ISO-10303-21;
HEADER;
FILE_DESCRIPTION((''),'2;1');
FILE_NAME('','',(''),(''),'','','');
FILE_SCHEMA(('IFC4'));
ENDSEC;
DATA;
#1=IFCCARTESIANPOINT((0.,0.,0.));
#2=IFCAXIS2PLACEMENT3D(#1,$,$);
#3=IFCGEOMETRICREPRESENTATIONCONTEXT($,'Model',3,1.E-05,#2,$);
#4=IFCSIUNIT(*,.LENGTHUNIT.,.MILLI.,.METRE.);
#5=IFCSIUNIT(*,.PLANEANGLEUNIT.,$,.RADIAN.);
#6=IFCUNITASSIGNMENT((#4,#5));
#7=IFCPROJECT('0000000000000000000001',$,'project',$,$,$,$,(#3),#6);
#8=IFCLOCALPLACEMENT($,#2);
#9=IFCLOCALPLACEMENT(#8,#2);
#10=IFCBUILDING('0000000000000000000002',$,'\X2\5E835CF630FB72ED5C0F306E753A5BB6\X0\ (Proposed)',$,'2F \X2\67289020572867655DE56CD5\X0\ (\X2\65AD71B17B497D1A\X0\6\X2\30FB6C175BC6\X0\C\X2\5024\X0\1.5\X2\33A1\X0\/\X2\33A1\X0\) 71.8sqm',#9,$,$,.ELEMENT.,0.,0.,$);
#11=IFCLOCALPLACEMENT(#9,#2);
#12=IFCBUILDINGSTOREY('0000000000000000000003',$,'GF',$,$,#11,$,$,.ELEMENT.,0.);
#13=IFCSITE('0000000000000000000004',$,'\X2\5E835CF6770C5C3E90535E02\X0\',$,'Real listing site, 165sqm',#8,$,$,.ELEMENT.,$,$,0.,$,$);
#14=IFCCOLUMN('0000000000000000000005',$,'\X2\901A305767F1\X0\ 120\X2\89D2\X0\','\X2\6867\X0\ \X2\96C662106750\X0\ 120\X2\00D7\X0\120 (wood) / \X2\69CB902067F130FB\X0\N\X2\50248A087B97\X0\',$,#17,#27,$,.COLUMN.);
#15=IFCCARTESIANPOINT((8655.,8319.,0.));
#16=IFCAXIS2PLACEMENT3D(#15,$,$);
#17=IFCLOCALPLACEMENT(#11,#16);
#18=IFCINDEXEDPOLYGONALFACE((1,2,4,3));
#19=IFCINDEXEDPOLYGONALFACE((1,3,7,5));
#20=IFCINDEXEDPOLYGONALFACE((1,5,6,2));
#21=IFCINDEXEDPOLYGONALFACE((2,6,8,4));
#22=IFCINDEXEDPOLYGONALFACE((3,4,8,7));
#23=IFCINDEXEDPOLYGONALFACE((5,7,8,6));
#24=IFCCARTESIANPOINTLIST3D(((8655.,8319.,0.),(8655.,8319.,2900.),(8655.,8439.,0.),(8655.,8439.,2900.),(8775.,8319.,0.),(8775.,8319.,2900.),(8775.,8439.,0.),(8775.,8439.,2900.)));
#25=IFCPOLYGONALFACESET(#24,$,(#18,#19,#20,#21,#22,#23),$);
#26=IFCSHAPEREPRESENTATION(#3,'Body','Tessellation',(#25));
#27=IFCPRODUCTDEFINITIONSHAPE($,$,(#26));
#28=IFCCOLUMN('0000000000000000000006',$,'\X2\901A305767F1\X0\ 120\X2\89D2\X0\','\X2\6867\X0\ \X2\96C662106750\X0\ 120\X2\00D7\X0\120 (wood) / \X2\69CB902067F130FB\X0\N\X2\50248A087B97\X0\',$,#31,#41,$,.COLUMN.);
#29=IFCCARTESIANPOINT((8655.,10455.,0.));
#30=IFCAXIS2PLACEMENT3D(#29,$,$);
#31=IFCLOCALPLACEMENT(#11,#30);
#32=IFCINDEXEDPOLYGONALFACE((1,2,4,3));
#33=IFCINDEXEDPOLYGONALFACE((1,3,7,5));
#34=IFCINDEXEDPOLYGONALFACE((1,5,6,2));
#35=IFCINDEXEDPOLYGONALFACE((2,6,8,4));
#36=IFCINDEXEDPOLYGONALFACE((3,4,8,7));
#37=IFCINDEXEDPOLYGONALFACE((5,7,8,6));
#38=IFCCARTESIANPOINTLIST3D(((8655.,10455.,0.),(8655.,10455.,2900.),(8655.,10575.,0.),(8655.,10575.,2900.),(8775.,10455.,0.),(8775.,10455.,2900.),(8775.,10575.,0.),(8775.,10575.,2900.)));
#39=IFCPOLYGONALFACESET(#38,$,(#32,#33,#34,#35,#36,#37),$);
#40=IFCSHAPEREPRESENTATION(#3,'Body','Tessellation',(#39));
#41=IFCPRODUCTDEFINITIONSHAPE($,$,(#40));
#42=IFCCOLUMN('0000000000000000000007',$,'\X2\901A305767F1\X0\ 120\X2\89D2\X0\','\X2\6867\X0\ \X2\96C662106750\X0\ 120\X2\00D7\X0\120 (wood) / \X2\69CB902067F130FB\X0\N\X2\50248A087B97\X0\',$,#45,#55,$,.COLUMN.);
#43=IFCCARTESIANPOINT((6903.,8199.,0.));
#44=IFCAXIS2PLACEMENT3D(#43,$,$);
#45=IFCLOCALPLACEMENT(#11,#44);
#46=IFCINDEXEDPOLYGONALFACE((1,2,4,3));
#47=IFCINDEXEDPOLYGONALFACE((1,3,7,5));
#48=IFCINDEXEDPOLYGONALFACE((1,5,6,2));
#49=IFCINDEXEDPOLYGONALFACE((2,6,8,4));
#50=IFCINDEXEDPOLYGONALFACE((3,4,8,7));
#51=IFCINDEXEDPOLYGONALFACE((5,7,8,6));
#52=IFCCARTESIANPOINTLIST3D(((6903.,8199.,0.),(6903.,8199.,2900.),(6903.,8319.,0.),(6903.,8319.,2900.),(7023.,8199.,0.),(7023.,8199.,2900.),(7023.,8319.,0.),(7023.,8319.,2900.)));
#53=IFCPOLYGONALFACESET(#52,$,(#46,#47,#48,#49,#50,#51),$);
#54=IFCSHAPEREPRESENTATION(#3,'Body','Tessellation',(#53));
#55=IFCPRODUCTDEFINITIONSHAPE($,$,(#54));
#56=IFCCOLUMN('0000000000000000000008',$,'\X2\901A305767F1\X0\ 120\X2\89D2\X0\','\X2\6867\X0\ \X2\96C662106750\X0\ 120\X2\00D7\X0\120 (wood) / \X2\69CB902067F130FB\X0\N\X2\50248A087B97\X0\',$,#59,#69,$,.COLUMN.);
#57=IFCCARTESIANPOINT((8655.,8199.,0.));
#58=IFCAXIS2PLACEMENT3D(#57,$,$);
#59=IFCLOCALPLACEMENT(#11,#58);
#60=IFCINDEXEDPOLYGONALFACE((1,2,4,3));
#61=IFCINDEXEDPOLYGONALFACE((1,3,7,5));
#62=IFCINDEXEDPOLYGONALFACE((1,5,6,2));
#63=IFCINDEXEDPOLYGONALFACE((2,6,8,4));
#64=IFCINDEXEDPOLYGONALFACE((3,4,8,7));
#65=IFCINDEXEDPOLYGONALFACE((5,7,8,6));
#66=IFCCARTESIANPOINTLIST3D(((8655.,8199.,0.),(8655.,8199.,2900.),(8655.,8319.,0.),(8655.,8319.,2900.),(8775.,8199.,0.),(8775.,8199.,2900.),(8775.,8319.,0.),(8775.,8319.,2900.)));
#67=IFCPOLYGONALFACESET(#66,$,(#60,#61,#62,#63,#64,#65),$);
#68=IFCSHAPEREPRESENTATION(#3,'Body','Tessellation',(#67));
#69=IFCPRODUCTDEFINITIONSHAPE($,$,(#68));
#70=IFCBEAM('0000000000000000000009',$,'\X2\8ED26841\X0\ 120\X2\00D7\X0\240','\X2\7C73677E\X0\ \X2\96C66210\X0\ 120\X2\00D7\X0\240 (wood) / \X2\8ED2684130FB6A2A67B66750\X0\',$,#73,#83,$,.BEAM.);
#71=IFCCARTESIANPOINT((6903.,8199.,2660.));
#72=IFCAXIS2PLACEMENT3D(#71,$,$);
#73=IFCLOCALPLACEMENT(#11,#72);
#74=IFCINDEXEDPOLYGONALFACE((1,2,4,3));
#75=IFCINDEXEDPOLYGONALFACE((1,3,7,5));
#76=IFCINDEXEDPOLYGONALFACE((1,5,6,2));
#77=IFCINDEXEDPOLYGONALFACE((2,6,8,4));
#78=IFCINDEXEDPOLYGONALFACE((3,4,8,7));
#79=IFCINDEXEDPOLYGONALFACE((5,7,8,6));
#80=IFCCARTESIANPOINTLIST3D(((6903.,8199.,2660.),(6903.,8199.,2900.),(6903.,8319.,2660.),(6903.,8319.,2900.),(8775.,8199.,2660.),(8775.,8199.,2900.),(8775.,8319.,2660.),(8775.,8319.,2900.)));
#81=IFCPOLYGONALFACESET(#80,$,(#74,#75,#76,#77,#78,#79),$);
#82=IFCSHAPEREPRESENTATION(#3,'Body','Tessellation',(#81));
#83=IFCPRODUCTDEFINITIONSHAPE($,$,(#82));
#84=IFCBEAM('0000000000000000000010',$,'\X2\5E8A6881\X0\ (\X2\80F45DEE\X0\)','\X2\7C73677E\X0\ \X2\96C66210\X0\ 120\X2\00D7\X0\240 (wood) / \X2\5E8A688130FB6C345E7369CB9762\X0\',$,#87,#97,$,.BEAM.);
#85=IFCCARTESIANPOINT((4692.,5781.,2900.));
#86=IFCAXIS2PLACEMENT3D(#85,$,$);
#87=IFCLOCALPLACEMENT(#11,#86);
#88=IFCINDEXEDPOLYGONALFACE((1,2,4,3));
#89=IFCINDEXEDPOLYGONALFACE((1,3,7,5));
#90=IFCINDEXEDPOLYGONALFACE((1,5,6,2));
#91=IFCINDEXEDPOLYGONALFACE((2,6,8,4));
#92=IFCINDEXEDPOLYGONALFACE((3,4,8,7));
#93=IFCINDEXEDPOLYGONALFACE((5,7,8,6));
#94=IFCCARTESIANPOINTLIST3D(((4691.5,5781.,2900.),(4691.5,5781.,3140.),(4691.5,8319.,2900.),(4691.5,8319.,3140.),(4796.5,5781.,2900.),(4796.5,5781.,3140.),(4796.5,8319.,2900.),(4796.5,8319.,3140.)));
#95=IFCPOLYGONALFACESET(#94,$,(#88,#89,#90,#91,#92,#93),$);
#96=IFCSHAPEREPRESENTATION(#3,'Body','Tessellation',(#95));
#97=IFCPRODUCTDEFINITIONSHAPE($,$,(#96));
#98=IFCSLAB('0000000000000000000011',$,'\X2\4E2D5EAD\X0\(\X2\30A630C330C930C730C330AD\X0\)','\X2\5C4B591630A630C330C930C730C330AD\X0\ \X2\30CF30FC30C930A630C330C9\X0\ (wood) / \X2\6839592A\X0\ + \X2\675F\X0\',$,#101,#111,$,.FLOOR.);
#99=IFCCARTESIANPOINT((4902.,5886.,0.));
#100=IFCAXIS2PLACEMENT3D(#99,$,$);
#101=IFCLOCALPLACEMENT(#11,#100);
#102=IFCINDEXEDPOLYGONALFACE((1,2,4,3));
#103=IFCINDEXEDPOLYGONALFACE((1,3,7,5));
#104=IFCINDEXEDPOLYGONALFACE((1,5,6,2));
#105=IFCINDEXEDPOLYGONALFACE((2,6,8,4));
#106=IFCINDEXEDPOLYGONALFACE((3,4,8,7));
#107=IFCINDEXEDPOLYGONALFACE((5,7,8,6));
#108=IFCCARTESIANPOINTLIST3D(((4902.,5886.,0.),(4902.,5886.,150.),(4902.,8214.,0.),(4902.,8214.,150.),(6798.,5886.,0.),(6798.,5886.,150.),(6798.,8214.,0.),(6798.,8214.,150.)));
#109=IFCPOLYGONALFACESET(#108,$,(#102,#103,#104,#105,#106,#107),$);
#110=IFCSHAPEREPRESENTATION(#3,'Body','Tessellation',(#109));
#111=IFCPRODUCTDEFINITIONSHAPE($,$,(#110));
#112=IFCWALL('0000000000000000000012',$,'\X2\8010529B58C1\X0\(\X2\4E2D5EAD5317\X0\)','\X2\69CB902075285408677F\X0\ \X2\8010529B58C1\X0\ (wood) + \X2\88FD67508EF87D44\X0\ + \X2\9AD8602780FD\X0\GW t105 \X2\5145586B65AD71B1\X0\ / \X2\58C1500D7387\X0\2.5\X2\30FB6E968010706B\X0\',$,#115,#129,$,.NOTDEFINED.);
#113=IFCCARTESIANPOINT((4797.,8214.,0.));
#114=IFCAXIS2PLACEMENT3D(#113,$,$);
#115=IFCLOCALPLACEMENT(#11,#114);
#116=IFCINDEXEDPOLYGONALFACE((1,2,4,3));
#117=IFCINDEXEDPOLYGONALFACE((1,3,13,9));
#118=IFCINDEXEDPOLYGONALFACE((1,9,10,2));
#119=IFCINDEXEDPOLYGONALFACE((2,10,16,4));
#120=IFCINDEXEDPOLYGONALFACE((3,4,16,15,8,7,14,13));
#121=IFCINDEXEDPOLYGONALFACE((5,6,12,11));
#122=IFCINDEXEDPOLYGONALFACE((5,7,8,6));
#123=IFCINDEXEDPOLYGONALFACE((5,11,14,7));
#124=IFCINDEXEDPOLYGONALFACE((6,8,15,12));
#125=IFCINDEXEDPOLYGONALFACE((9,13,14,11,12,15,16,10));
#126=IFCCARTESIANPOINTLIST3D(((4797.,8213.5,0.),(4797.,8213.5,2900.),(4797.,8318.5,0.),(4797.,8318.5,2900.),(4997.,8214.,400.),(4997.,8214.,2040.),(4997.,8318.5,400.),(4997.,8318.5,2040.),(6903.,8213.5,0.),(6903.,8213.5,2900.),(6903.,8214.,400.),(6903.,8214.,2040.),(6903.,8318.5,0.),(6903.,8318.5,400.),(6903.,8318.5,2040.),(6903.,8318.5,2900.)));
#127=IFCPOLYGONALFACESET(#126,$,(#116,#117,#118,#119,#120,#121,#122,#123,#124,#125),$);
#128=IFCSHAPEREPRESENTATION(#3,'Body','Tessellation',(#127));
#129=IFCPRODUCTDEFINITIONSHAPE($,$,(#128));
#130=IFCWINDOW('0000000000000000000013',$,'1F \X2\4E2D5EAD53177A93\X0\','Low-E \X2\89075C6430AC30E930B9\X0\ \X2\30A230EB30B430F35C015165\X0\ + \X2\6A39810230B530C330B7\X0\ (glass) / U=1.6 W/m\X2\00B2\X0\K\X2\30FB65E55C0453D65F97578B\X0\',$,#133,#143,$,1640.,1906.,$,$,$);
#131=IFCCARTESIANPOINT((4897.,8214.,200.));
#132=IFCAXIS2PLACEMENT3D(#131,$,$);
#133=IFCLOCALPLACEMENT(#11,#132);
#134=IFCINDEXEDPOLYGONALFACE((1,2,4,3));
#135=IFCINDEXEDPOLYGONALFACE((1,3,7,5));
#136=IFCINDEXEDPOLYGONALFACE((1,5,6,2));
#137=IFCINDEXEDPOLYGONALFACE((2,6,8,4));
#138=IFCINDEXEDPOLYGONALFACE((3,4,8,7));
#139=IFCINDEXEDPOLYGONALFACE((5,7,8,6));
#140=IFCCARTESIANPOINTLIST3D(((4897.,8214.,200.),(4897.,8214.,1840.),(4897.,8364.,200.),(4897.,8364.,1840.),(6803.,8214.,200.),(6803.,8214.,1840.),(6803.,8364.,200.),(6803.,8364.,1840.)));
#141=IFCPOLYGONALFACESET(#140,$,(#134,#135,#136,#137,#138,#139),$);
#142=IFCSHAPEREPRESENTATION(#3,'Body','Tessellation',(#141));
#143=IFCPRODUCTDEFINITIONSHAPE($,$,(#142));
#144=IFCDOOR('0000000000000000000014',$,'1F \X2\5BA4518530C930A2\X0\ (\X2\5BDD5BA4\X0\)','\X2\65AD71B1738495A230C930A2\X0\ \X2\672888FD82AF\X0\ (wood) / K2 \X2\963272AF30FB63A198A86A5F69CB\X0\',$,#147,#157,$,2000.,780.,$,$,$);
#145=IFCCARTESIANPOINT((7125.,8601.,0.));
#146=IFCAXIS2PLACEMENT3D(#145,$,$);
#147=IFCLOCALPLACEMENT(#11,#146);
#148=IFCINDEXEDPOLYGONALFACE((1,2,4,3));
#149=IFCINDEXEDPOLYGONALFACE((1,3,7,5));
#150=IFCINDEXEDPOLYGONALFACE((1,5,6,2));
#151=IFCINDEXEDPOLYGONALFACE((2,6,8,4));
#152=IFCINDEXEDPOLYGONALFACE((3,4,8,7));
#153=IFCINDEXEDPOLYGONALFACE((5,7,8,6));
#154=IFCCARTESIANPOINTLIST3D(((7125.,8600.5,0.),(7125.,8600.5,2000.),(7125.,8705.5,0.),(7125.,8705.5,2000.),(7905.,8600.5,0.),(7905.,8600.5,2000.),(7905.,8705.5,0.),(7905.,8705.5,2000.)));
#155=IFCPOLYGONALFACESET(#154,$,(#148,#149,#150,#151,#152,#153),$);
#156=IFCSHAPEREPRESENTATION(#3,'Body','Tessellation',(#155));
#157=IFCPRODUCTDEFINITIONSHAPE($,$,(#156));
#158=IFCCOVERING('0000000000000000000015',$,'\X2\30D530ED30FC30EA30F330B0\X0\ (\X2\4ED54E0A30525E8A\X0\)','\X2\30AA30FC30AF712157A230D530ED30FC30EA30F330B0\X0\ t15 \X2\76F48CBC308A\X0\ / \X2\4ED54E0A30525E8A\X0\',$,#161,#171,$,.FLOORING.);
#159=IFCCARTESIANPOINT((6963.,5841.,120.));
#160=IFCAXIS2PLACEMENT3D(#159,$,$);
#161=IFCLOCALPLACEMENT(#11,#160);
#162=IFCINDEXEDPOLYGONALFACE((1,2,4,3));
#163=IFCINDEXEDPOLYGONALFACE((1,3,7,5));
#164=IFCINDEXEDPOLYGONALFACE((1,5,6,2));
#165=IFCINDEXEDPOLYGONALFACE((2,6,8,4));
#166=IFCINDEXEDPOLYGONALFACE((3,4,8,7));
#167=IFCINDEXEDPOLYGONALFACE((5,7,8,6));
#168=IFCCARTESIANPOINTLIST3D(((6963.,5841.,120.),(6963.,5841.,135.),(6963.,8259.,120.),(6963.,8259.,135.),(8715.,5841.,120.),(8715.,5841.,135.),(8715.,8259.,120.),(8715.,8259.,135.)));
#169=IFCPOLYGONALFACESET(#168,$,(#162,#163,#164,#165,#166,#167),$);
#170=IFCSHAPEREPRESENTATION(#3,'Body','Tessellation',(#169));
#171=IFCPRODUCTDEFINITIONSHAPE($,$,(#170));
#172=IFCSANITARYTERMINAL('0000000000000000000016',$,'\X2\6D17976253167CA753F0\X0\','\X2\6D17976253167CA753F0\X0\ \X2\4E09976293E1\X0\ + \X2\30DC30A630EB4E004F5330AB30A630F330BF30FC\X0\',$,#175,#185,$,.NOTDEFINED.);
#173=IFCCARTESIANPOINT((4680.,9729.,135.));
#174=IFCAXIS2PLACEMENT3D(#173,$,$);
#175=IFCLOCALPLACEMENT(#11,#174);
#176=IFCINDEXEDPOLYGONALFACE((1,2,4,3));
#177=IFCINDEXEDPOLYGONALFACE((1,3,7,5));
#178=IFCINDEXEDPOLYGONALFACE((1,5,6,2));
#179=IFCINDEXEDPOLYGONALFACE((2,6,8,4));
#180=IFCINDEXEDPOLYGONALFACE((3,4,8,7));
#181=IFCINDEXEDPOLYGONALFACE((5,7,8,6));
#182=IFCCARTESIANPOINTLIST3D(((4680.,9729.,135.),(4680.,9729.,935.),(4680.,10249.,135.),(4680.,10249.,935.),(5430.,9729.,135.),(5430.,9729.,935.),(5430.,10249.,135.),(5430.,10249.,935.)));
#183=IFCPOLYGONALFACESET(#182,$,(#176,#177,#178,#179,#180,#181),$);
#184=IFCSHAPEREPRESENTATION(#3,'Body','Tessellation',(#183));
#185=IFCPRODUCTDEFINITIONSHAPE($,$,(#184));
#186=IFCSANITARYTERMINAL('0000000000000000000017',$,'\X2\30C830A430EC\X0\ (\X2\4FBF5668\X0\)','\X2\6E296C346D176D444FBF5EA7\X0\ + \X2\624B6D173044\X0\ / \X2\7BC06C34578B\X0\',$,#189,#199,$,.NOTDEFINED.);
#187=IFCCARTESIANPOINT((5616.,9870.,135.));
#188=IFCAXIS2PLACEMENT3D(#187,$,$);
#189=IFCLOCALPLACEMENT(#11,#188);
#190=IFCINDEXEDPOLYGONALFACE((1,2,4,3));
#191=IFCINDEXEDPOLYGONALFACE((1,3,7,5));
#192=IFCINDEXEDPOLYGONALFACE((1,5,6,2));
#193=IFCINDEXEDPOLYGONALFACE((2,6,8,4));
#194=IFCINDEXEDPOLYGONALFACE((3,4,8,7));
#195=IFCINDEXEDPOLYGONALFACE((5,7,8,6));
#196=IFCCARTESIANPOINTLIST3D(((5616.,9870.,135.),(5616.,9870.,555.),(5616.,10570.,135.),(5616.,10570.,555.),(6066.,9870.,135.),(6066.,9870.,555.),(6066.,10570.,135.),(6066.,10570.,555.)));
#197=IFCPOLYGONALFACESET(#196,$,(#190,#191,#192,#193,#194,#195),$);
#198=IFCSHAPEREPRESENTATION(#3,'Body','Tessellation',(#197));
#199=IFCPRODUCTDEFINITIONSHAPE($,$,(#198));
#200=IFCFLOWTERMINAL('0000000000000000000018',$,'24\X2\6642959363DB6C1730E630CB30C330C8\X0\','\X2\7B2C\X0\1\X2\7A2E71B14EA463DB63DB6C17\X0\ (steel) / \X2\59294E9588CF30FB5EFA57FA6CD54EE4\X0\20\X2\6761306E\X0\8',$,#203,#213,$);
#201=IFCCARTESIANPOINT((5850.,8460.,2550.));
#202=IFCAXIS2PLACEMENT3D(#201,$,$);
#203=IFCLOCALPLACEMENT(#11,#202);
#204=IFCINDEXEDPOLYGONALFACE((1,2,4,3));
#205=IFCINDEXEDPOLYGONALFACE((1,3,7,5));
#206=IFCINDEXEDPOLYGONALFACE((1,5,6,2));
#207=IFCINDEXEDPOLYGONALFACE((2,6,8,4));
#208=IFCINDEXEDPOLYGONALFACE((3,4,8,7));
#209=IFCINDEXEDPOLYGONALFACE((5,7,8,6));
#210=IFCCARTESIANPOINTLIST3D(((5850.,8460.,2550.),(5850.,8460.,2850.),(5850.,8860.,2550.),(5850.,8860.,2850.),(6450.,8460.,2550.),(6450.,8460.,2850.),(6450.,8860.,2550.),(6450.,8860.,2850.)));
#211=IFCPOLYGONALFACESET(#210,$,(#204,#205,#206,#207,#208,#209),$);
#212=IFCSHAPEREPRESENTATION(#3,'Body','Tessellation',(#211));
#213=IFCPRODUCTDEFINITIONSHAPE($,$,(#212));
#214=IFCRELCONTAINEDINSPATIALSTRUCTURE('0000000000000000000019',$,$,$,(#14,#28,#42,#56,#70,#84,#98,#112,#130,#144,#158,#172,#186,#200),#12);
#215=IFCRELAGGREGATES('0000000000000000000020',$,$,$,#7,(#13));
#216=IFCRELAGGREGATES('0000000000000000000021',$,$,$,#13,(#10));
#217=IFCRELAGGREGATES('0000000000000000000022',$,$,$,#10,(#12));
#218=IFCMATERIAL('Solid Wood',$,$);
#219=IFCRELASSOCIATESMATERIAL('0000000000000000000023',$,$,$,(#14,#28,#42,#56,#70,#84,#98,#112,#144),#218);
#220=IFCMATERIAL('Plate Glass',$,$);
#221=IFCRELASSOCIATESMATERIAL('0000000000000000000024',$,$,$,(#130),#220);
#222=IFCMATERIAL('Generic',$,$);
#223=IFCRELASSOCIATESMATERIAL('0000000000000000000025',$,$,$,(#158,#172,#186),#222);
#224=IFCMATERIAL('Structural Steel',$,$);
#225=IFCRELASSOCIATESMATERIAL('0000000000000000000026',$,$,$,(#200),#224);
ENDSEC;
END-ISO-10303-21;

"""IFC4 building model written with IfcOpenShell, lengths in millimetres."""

from ifc_helpers import new_model, si_unit, frame, frame_2d, origin, place, context, project, spatial, rectangle, extrude, material, element, fill, save


model = new_model("IFC4")

# Units and contexts
model_context = context("Model", 3, precision=1e-05, world=origin())
ifc_project = project(units=[si_unit("LENGTHUNIT", "METRE", prefix="MILLI"), si_unit("PLANEANGLEUNIT", "RADIAN")], contexts=[model_context])

# Site, building, storey
site_placement = place(None, origin())
site = spatial("IfcSite", under=ifc_project, at=site_placement, Name="広島県尾道市", ObjectType="Real listing site, 165sqm", CompositionType="ELEMENT", RefElevation=0.0)
building_placement = place(site_placement, origin())
building = spatial("IfcBuilding", under=site, at=building_placement, Name="広島・狭小の町家 (Proposed)", ObjectType="2F 木造在来工法 (断熱等級6・気密C値1.5㎡/㎡) 71.8sqm", CompositionType="ELEMENT", ElevationOfRefHeight=0.0, ElevationOfTerrain=0.0)
storey_placement = place(building_placement, origin())
storey = spatial("IfcBuildingStorey", under=building, at=storey_placement, Name="GF", CompositionType="ELEMENT", Elevation=0.0)

# Columns
ifc_material_1 = material(Name="Solid Wood")
column_1_placement = place(storey_placement, frame((8655.0, 8319.0, 0.0)))
element("IfcColumn", 1, at=column_1_placement, inside=storey, material=ifc_material_1, Name="通し柱 120角", Description="桧 集成材 120×120 (wood) / 構造柱・N値計算", PredefinedType="COLUMN", context=model_context, shape_type="SweptSolid", body=[
    extrude(rectangle(XDim=120.0, YDim=120.0, at=frame_2d((60.0, 60.0))), frame((8655.0, 8319.0, 0.0)), (0.0, 0.0, 1.0), 2900.0),
])
column_2_placement = place(storey_placement, frame((8655.0, 10455.0, 0.0)))
element("IfcColumn", 2, at=column_2_placement, inside=storey, material=ifc_material_1, Name="通し柱 120角", Description="桧 集成材 120×120 (wood) / 構造柱・N値計算", PredefinedType="COLUMN", context=model_context, shape_type="SweptSolid", body=[
    extrude(rectangle(XDim=120.0, YDim=120.0, at=frame_2d((60.0, 60.0))), frame((8655.0, 10455.0, 0.0)), (0.0, 0.0, 1.0), 2900.0),
])
column_3_placement = place(storey_placement, frame((6903.0, 8199.0, 0.0)))
element("IfcColumn", 3, at=column_3_placement, inside=storey, material=ifc_material_1, Name="通し柱 120角", Description="桧 集成材 120×120 (wood) / 構造柱・N値計算", PredefinedType="COLUMN", context=model_context, shape_type="SweptSolid", body=[
    extrude(rectangle(XDim=120.0, YDim=120.0, at=frame_2d((60.0, 60.0))), frame((6903.0, 8199.0, 0.0)), (0.0, 0.0, 1.0), 2900.0),
])
column_4_placement = place(storey_placement, frame((8655.0, 8199.0, 0.0)))
element("IfcColumn", 4, at=column_4_placement, inside=storey, material=ifc_material_1, Name="通し柱 120角", Description="桧 集成材 120×120 (wood) / 構造柱・N値計算", PredefinedType="COLUMN", context=model_context, shape_type="SweptSolid", body=[
    extrude(rectangle(XDim=120.0, YDim=120.0, at=frame_2d((60.0, 60.0))), frame((8655.0, 8199.0, 0.0)), (0.0, 0.0, 1.0), 2900.0),
])

# Beams
beam_1_placement = place(storey_placement, frame((6903.0, 8199.0, 2660.0)))
element("IfcBeam", 5, at=beam_1_placement, inside=storey, material=ifc_material_1, Name="軒桁 120×240", Description="米松 集成 120×240 (wood) / 軒桁・横架材", PredefinedType="BEAM", context=model_context, shape_type="SweptSolid", body=[
    extrude(rectangle(XDim=1872.0, YDim=120.0, at=frame_2d((936.0, 60.0))), frame((6903.0, 8199.0, 2660.0)), (0.0, 0.0, 1.0), 240.0),
])
beam_2_placement = place(storey_placement, frame((4692.0, 5781.0, 2900.0)))
element("IfcBeam", 6, at=beam_2_placement, inside=storey, material=ifc_material_1, Name="床梁 (胴差)", Description="米松 集成 120×240 (wood) / 床梁・水平構面", PredefinedType="BEAM", context=model_context, shape_type="SweptSolid", body=[
    extrude(rectangle(XDim=105.0, YDim=2538.0, at=frame_2d((52.0, 1269.0))), frame((4692.0, 5781.0, 2900.0)), (0.0, 0.0, 1.0), 240.0),
])

# Slab
slab_placement = place(storey_placement, frame((4902.0, 5886.0, 0.0)))
element("IfcSlab", 7, at=slab_placement, inside=storey, material=ifc_material_1, Name="中庭(ウッドデッキ)", Description="屋外ウッドデッキ ハードウッド (wood) / 根太 + 束", PredefinedType="FLOOR", context=model_context, shape_type="SweptSolid", body=[
    extrude(rectangle(XDim=1896.0, YDim=2328.0, at=frame_2d((948.0, 1164.0))), frame((4902.0, 5886.0, 0.0)), (0.0, 0.0, 1.0), 150.0),
])

# Wall, opening, window
wall_1_placement = place(storey_placement, frame((4797.0, 8214.0, 0.0)))
wall_1 = element("IfcWall", 8, at=wall_1_placement, inside=storey, material=ifc_material_1, Name="耐力壁(中庭北)", Description="構造用合板 耐力壁 (wood) + 製材軸組 + 高性能GW t105 充填断熱 / 壁倍率2.5・準耐火", PredefinedType="NOTDEFINED", context=model_context, shape_type="SweptSolid", body=[
    extrude(rectangle(XDim=2106.0, YDim=105.0, at=frame_2d((1053.0, 52.0))), frame((4797.0, 8214.0, 0.0)), (0.0, 0.0, 1.0), 2900.0),
])
opening_placement = place(storey_placement, frame((4897.0, 8214.0, 200.0)))
opening = element("IfcOpeningElement", 9, at=opening_placement, cuts=wall_1, PredefinedType="NOTDEFINED", context=model_context, shape_type="SweptSolid", body=[
    extrude(rectangle(XDim=1906.0, YDim=150.0, at=frame_2d((953.0, 75.0))), frame((4897.0, 8214.0, 200.0)), (0.0, 0.0, 1.0), 1640.0),
])
ifc_material_2 = material(Name="Plate Glass")
window_placement = place(storey_placement, frame((4897.0, 8214.0, 200.0)))
window = element("IfcWindow", 10, at=window_placement, inside=storey, material=ifc_material_2, Name="1F 中庭北窓", Description="Low-E 複層ガラス アルゴン封入 + 樹脂サッシ (glass) / U=1.6 W/m²K・日射取得型", OverallHeight=1640.0, OverallWidth=1906.0, context=model_context, shape_type="SweptSolid", body=[
    extrude(rectangle(XDim=1906.0, YDim=150.0, at=frame_2d((953.0, 75.0))), frame((4897.0, 8214.0, 200.0)), (0.0, 0.0, 1.0), 1640.0),
])
fill(opening, window)

# Door
door_placement = place(storey_placement, frame((7125.0, 8601.0, 0.0)))
element("IfcDoor", 11, at=door_placement, inside=storey, material=ifc_material_1, Name="1F 室内ドア (寝室)", Description="断熱玄関ドア 木製芯 (wood) / K2 防犯・採風機構", OverallHeight=2000.0, OverallWidth=780.0, context=model_context, shape_type="SweptSolid", body=[
    extrude(rectangle(XDim=780.0, YDim=105.0, at=frame_2d((390.0, 52.0))), frame((7125.0, 8601.0, 0.0)), (0.0, 0.0, 1.0), 2000.0),
])

# Covering
ifc_material_3 = material(Name="Generic")
covering_placement = place(storey_placement, frame((6963.0, 5841.0, 120.0)))
element("IfcCovering", 12, at=covering_placement, inside=storey, material=ifc_material_3, Name="フローリング (仕上げ床)", Description="オーク無垢フローリング t15 直貼り / 仕上げ床", PredefinedType="FLOORING", context=model_context, shape_type="SweptSolid", body=[
    extrude(rectangle(XDim=1752.0, YDim=2418.0, at=frame_2d((876.0, 1209.0))), frame((6963.0, 5841.0, 120.0)), (0.0, 0.0, 1.0), 15.0),
])

# Sanitary terminals
sanitary_terminal_1_placement = place(storey_placement, frame((4680.0, 9729.0, 135.0)))
element("IfcSanitaryTerminal", 13, at=sanitary_terminal_1_placement, inside=storey, material=ifc_material_3, Name="洗面化粧台", Description="洗面化粧台 三面鏡 + ボウル一体カウンター", PredefinedType="NOTDEFINED", context=model_context, shape_type="SweptSolid", body=[
    extrude(rectangle(XDim=750.0, YDim=520.0, at=frame_2d((375.0, 260.0))), frame((4680.0, 9729.0, 135.0)), (0.0, 0.0, 1.0), 800.0),
])
sanitary_terminal_2_placement = place(storey_placement, frame((5616.0, 9870.0, 135.0)))
element("IfcSanitaryTerminal", 14, at=sanitary_terminal_2_placement, inside=storey, material=ifc_material_3, Name="トイレ (便器)", Description="温水洗浄便座 + 手洗い / 節水型", PredefinedType="NOTDEFINED", context=model_context, shape_type="SweptSolid", body=[
    extrude(rectangle(XDim=450.0, YDim=700.0, at=frame_2d((225.0, 350.0))), frame((5616.0, 9870.0, 135.0)), (0.0, 0.0, 1.0), 420.0),
])

# Flow terminal
ifc_material_4 = material(Name="Structural Steel")
flow_terminal_placement = place(storey_placement, frame((5850.0, 8460.0, 2550.0)))
element("IfcFlowTerminal", 15, at=flow_terminal_placement, inside=storey, material=ifc_material_4, Name="24時間換気ユニット", Description="第1種熱交換換気 (steel) / 天井裏・建基法令20条の8", context=model_context, shape_type="SweptSolid", body=[
    extrude(rectangle(XDim=600.0, YDim=400.0, at=frame_2d((300.0, 200.0))), frame((5850.0, 8460.0, 2550.0)), (0.0, 0.0, 1.0), 300.0),
])

save(model, "model.ifc")
